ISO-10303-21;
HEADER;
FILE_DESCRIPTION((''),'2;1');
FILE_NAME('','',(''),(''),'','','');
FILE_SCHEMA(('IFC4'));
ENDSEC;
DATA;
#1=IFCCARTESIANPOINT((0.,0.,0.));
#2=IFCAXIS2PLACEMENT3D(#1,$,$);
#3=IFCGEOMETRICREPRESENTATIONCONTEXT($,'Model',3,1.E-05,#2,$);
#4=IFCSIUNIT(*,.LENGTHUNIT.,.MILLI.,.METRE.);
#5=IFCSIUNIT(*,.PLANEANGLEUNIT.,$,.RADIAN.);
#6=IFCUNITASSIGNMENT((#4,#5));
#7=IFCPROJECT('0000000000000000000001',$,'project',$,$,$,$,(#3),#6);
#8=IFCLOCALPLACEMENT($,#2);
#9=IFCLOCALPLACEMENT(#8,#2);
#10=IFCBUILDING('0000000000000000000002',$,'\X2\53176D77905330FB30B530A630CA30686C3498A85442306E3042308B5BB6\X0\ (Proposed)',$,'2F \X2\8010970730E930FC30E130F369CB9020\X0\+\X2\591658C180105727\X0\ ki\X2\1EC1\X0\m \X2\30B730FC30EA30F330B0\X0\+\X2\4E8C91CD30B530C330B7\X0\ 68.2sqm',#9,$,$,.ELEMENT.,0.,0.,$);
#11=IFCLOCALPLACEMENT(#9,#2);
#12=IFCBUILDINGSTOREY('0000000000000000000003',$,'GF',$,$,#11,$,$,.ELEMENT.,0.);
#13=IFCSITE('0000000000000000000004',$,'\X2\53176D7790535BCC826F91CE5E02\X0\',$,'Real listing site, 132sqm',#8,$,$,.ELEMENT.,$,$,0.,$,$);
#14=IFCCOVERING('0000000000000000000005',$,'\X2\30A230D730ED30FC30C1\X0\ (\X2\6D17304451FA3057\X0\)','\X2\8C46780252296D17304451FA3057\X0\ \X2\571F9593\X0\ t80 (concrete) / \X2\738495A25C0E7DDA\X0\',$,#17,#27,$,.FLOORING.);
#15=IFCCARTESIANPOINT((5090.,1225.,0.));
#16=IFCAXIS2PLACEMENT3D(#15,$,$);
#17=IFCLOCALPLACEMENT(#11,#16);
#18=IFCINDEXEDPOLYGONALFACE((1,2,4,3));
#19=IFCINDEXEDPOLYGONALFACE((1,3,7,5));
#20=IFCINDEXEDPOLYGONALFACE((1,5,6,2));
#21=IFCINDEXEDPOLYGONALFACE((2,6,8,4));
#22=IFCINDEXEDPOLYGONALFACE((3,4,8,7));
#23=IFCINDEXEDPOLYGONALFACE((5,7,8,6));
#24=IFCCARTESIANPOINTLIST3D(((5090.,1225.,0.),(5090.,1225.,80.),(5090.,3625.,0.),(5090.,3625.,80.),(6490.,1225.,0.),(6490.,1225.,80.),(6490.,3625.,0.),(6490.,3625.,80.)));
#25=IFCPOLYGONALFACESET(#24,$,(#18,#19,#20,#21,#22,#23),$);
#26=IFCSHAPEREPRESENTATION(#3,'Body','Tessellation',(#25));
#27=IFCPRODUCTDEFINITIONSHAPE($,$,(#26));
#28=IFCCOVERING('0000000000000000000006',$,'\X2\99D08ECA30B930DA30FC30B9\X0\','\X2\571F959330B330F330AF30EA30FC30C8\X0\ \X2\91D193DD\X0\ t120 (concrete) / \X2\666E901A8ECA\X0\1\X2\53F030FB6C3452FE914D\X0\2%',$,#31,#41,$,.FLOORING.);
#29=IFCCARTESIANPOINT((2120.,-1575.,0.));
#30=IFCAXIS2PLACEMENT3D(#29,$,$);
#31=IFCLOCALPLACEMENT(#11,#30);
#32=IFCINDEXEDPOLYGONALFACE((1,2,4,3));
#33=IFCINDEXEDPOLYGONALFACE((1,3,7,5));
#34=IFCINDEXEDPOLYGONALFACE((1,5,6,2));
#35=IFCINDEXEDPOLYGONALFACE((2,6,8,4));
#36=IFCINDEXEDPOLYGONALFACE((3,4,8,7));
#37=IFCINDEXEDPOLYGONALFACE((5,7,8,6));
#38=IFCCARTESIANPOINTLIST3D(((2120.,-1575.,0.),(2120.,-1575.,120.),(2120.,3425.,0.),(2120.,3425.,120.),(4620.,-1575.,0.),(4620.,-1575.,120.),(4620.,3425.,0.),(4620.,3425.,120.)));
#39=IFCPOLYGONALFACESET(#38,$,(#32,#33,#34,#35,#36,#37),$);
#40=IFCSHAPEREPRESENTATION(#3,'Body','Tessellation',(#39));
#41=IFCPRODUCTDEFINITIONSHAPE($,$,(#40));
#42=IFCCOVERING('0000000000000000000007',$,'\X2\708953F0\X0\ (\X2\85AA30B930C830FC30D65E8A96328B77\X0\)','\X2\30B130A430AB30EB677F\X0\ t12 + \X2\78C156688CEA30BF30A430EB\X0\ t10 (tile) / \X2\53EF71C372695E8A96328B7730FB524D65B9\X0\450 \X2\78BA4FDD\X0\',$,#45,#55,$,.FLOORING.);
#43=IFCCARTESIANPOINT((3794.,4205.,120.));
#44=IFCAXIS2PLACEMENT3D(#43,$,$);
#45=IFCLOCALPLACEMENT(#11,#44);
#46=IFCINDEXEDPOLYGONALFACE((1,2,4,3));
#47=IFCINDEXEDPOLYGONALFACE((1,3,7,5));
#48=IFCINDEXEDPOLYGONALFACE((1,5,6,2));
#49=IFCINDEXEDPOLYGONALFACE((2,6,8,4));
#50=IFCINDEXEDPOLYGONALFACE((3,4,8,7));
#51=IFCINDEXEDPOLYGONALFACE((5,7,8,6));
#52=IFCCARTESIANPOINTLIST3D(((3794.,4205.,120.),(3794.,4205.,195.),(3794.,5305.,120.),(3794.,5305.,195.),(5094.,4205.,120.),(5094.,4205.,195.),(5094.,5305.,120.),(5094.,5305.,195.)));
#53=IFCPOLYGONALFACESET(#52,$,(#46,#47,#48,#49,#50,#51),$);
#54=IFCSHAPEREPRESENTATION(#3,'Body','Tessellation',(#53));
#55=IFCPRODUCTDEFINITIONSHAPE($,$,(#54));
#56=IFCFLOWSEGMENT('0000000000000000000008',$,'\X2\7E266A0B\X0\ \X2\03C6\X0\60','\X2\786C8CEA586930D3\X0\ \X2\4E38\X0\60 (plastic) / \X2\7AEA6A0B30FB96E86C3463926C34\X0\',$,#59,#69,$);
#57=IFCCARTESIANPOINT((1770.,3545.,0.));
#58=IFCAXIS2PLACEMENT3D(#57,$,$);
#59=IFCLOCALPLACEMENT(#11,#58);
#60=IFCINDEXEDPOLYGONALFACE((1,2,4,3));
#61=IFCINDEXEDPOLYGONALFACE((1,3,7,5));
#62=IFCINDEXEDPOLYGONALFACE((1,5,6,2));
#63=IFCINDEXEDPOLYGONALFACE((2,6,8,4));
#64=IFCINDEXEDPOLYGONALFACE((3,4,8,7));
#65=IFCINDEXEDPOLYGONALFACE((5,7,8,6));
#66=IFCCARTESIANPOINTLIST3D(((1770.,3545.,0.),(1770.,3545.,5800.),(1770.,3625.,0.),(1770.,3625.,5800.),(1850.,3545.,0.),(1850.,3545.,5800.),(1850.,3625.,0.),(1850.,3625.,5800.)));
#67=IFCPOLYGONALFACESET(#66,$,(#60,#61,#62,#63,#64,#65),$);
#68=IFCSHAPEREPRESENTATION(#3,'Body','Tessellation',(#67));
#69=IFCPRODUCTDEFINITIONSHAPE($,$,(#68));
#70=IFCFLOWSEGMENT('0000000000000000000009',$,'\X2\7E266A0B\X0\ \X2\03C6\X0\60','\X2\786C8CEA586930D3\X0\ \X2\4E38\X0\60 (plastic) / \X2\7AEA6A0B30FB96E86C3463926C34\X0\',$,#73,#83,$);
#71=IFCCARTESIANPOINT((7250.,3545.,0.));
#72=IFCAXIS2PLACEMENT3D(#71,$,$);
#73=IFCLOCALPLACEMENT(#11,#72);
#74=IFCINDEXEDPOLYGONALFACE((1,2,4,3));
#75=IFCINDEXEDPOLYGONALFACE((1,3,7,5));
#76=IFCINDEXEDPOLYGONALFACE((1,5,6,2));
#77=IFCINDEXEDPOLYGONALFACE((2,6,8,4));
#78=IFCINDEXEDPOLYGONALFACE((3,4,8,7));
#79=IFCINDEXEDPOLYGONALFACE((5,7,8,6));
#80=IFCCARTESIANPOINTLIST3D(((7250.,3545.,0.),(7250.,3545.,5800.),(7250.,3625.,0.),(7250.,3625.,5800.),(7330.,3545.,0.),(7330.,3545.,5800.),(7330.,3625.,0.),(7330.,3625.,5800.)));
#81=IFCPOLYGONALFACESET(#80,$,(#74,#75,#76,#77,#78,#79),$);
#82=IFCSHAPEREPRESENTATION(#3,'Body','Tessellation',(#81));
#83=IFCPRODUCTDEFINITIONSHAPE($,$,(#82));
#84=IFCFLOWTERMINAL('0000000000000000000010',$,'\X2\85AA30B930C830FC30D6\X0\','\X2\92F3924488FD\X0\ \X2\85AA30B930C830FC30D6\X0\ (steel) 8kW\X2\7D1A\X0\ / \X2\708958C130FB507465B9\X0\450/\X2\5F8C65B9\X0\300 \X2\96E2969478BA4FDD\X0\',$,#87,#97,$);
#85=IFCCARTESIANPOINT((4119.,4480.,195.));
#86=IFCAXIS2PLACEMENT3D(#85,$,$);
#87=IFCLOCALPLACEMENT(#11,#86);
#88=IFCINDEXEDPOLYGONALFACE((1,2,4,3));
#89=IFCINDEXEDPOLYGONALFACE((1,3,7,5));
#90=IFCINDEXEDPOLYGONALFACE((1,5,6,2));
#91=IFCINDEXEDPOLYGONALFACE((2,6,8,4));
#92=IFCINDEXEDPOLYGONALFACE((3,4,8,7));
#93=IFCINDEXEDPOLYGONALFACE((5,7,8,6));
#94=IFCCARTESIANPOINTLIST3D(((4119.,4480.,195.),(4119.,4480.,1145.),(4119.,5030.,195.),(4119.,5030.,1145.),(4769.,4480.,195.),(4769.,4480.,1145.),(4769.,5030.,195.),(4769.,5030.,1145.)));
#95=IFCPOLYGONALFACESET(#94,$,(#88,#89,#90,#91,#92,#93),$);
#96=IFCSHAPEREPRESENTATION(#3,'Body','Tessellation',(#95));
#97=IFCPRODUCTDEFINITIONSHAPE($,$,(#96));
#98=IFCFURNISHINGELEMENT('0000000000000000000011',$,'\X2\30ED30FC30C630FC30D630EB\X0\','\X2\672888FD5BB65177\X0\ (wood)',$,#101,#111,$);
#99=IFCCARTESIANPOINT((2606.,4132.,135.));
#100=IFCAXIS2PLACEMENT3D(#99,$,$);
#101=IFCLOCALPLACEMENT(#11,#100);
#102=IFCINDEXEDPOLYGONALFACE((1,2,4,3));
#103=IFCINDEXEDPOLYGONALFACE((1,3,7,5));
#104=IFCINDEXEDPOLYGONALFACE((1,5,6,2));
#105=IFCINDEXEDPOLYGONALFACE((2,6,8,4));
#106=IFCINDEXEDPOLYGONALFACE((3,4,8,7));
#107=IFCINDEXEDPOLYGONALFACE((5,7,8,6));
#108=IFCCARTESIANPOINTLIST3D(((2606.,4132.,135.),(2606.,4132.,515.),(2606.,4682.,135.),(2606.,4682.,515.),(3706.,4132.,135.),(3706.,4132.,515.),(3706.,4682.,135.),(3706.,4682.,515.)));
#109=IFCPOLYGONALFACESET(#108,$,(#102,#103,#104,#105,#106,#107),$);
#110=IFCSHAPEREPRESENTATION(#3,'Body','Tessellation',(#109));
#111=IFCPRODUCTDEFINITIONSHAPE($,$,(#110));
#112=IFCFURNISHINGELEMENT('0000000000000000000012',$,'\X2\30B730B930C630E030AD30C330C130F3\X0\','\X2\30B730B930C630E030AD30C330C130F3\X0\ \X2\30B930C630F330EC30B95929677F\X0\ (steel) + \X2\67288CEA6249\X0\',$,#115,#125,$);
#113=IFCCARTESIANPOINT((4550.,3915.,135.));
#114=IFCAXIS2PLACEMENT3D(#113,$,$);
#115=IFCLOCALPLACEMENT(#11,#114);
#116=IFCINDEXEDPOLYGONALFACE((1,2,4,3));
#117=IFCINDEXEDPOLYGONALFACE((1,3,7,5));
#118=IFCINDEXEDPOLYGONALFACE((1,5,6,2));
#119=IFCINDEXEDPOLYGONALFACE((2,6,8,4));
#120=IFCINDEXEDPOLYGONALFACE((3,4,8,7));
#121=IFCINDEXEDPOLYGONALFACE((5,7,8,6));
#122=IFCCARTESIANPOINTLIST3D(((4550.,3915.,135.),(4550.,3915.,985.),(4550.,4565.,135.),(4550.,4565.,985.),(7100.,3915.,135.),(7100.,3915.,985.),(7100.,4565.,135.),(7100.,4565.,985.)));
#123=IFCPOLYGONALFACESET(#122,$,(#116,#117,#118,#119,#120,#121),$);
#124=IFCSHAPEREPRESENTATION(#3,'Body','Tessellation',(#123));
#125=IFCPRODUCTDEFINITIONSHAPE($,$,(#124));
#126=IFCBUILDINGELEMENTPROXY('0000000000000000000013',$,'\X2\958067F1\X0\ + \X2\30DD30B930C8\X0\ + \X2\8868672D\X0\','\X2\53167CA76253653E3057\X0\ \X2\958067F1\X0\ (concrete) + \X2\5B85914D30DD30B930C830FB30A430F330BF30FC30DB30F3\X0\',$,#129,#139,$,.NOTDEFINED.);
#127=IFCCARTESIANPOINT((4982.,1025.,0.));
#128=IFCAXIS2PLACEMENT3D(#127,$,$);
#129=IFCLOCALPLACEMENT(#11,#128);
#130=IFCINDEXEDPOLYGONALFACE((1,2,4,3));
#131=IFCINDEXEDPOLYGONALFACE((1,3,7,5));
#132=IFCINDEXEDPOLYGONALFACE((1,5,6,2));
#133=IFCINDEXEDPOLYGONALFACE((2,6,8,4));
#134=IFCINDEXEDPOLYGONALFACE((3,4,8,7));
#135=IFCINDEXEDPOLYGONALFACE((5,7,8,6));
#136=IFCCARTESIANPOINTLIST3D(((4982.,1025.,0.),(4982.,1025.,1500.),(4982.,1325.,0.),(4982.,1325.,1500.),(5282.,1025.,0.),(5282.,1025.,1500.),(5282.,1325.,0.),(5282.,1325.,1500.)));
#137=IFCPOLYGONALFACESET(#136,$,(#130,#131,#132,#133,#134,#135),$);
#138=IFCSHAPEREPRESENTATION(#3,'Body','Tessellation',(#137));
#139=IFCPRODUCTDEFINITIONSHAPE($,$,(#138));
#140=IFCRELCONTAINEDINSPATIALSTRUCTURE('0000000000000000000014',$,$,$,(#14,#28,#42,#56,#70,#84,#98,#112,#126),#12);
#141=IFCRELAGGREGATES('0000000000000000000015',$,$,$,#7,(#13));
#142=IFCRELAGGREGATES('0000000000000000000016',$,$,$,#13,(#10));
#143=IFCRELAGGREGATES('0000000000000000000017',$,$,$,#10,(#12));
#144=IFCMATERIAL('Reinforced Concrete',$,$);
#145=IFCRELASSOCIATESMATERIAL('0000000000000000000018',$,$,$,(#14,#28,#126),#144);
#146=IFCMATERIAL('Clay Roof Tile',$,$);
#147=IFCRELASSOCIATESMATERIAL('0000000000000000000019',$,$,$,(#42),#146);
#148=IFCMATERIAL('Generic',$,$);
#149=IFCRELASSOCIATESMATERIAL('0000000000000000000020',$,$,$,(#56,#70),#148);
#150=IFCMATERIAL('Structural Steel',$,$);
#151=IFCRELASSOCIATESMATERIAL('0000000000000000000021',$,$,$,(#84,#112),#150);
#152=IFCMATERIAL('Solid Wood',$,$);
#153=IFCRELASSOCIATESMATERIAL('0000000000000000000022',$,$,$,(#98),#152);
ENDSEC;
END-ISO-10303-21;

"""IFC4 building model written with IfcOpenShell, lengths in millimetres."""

from ifc_helpers import new_model, si_unit, frame, frame_2d, origin, place, context, project, spatial, rectangle, extrude, material, element, save


model = new_model("IFC4")

# Units and contexts
model_context = context("Model", 3, precision=1e-05, world=origin())
ifc_project = project(units=[si_unit("LENGTHUNIT", "METRE", prefix="MILLI"), si_unit("PLANEANGLEUNIT", "RADIAN")], contexts=[model_context])

# Site, building, storey
site_placement = place(None, origin())
site = spatial("IfcSite", under=ifc_project, at=site_placement, Name="北海道富良野市", ObjectType="Real listing site, 132sqm", CompositionType="ELEMENT", RefElevation=0.0)
building_placement = place(site_placement, origin())
building = spatial("IfcBuilding", under=site, at=building_placement, Name="北海道・サウナと水風呂のある家 (Proposed)", ObjectType="2F 耐震ラーメン構造+外壁耐圧 kiềm シーリング+二重サッシ 68.2sqm", CompositionType="ELEMENT", ElevationOfRefHeight=0.0, ElevationOfTerrain=0.0)
storey_placement = place(building_placement, origin())
storey = spatial("IfcBuildingStorey", under=building, at=storey_placement, Name="GF", CompositionType="ELEMENT", Elevation=0.0)

# Shared definitions
ifc_material_1 = material(Name="Solid Wood")

# Shared definitions
ifc_material_2 = material(Name="Reinforced Concrete")

# Coverings
ifc_material_3 = material(Name="Generic")
covering_1_placement = place(storey_placement, frame((5090.0, 1225.0, 0.0)))
element("IfcCovering", 1, at=covering_1_placement, inside=storey, material=ifc_material_2, Name="アプローチ (洗い出し)", Description="豆砂利洗い出し 土間 t80 (concrete) / 玄関導線", PredefinedType="FLOORING", context=model_context, shape_type="SweptSolid", body=[
    extrude(rectangle(XDim=1400.0, YDim=2400.0, at=frame_2d((700.0, 1200.0))), frame((5090.0, 1225.0, 0.0)), (0.0, 0.0, 1.0), 80.0),
])
covering_2_placement = place(storey_placement, frame((2120.0, -1575.0, 0.0)))
element("IfcCovering", 2, at=covering_2_placement, inside=storey, material=ifc_material_2, Name="駐車スペース", Description="土間コンクリート 金鏝 t120 (concrete) / 普通車1台・水勾配2%", PredefinedType="FLOORING", context=model_context, shape_type="SweptSolid", body=[
    extrude(rectangle(XDim=2500.0, YDim=5000.0, at=frame_2d((1250.0, 2500.0))), frame((2120.0, -1575.0, 0.0)), (0.0, 0.0, 1.0), 120.0),
])
ifc_material_4 = material(Name="Clay Roof Tile")
covering_3_placement = place(storey_placement, frame((3794.0, 4205.0, 120.0)))
element("IfcCovering", 3, at=covering_3_placement, inside=storey, material=ifc_material_4, Name="炉台 (薪ストーブ床防護)", Description="ケイカル板 t12 + 磁器質タイル t10 (tile) / 可燃物床防護・前方450 確保", PredefinedType="FLOORING", context=model_context, shape_type="SweptSolid", body=[
    extrude(rectangle(XDim=1300.0, YDim=1100.0, at=frame_2d((650.0, 550.0))), frame((3794.0, 4205.0, 120.0)), (0.0, 0.0, 1.0), 75.0),
])

# Flow segments
flow_segment_1_placement = place(storey_placement, frame((1770.0, 3545.0, 0.0)))
element("IfcFlowSegment", 4, at=flow_segment_1_placement, inside=storey, material=ifc_material_3, Name="縦樋 φ60", Description="硬質塩ビ 丸60 (plastic) / 竪樋・雨水排水", context=model_context, shape_type="SweptSolid", body=[
    extrude(rectangle(XDim=80.0, YDim=80.0, at=frame_2d((40.0, 40.0))), frame((1770.0, 3545.0, 0.0)), (0.0, 0.0, 1.0), 5800.0),
])
flow_segment_2_placement = place(storey_placement, frame((7250.0, 3545.0, 0.0)))
element("IfcFlowSegment", 5, at=flow_segment_2_placement, inside=storey, material=ifc_material_3, Name="縦樋 φ60", Description="硬質塩ビ 丸60 (plastic) / 竪樋・雨水排水", context=model_context, shape_type="SweptSolid", body=[
    extrude(rectangle(XDim=80.0, YDim=80.0, at=frame_2d((40.0, 40.0))), frame((7250.0, 3545.0, 0.0)), (0.0, 0.0, 1.0), 5800.0),
])

# Flow terminal
ifc_material_5 = material(Name="Structural Steel")
flow_terminal_placement = place(storey_placement, frame((4119.0, 4480.0, 195.0)))
element("IfcFlowTerminal", 6, at=flow_terminal_placement, inside=storey, material=ifc_material_5, Name="薪ストーブ", Description="鋳鉄製 薪ストーブ (steel) 8kW級 / 炉壁・側方450/後方300 離隔確保", context=model_context, shape_type="SweptSolid", body=[
    extrude(rectangle(XDim=650.0, YDim=550.0, at=frame_2d((325.0, 275.0))), frame((4119.0, 4480.0, 195.0)), (0.0, 0.0, 1.0), 950.0),
])

# Furnishing elements
furnishing_1_placement = place(storey_placement, frame((2606.0, 4132.0, 135.0)))
element("IfcFurnishingElement", 7, at=furnishing_1_placement, inside=storey, material=ifc_material_1, Name="ローテーブル", Description="木製家具 (wood)", context=model_context, shape_type="SweptSolid", body=[
    extrude(rectangle(XDim=1100.0, YDim=550.0, at=frame_2d((550.0, 275.0))), frame((2606.0, 4132.0, 135.0)), (0.0, 0.0, 1.0), 380.0),
])
furnishing_2_placement = place(storey_placement, frame((4550.0, 3915.0, 135.0)))
element("IfcFurnishingElement", 8, at=furnishing_2_placement, inside=storey, material=ifc_material_5, Name="システムキッチン", Description="システムキッチン ステンレス天板 (steel) + 木質扉", context=model_context, shape_type="SweptSolid", body=[
    extrude(rectangle(XDim=2550.0, YDim=650.0, at=frame_2d((1275.0, 325.0))), frame((4550.0, 3915.0, 135.0)), (0.0, 0.0, 1.0), 850.0),
])

# Building element proxy
proxy_placement = place(storey_placement, frame((4982.0, 1025.0, 0.0)))
element("IfcBuildingElementProxy", 9, at=proxy_placement, inside=storey, material=ifc_material_2, Name="門柱 + ポスト + 表札", Description="化粧打放し 門柱 (concrete) + 宅配ポスト・インターホン", PredefinedType="NOTDEFINED", context=model_context, shape_type="SweptSolid", body=[
    extrude(rectangle(XDim=300.0, YDim=300.0, at=frame_2d((150.0, 150.0))), frame((4982.0, 1025.0, 0.0)), (0.0, 0.0, 1.0), 1500.0),
])

save(model, "model.ifc")
